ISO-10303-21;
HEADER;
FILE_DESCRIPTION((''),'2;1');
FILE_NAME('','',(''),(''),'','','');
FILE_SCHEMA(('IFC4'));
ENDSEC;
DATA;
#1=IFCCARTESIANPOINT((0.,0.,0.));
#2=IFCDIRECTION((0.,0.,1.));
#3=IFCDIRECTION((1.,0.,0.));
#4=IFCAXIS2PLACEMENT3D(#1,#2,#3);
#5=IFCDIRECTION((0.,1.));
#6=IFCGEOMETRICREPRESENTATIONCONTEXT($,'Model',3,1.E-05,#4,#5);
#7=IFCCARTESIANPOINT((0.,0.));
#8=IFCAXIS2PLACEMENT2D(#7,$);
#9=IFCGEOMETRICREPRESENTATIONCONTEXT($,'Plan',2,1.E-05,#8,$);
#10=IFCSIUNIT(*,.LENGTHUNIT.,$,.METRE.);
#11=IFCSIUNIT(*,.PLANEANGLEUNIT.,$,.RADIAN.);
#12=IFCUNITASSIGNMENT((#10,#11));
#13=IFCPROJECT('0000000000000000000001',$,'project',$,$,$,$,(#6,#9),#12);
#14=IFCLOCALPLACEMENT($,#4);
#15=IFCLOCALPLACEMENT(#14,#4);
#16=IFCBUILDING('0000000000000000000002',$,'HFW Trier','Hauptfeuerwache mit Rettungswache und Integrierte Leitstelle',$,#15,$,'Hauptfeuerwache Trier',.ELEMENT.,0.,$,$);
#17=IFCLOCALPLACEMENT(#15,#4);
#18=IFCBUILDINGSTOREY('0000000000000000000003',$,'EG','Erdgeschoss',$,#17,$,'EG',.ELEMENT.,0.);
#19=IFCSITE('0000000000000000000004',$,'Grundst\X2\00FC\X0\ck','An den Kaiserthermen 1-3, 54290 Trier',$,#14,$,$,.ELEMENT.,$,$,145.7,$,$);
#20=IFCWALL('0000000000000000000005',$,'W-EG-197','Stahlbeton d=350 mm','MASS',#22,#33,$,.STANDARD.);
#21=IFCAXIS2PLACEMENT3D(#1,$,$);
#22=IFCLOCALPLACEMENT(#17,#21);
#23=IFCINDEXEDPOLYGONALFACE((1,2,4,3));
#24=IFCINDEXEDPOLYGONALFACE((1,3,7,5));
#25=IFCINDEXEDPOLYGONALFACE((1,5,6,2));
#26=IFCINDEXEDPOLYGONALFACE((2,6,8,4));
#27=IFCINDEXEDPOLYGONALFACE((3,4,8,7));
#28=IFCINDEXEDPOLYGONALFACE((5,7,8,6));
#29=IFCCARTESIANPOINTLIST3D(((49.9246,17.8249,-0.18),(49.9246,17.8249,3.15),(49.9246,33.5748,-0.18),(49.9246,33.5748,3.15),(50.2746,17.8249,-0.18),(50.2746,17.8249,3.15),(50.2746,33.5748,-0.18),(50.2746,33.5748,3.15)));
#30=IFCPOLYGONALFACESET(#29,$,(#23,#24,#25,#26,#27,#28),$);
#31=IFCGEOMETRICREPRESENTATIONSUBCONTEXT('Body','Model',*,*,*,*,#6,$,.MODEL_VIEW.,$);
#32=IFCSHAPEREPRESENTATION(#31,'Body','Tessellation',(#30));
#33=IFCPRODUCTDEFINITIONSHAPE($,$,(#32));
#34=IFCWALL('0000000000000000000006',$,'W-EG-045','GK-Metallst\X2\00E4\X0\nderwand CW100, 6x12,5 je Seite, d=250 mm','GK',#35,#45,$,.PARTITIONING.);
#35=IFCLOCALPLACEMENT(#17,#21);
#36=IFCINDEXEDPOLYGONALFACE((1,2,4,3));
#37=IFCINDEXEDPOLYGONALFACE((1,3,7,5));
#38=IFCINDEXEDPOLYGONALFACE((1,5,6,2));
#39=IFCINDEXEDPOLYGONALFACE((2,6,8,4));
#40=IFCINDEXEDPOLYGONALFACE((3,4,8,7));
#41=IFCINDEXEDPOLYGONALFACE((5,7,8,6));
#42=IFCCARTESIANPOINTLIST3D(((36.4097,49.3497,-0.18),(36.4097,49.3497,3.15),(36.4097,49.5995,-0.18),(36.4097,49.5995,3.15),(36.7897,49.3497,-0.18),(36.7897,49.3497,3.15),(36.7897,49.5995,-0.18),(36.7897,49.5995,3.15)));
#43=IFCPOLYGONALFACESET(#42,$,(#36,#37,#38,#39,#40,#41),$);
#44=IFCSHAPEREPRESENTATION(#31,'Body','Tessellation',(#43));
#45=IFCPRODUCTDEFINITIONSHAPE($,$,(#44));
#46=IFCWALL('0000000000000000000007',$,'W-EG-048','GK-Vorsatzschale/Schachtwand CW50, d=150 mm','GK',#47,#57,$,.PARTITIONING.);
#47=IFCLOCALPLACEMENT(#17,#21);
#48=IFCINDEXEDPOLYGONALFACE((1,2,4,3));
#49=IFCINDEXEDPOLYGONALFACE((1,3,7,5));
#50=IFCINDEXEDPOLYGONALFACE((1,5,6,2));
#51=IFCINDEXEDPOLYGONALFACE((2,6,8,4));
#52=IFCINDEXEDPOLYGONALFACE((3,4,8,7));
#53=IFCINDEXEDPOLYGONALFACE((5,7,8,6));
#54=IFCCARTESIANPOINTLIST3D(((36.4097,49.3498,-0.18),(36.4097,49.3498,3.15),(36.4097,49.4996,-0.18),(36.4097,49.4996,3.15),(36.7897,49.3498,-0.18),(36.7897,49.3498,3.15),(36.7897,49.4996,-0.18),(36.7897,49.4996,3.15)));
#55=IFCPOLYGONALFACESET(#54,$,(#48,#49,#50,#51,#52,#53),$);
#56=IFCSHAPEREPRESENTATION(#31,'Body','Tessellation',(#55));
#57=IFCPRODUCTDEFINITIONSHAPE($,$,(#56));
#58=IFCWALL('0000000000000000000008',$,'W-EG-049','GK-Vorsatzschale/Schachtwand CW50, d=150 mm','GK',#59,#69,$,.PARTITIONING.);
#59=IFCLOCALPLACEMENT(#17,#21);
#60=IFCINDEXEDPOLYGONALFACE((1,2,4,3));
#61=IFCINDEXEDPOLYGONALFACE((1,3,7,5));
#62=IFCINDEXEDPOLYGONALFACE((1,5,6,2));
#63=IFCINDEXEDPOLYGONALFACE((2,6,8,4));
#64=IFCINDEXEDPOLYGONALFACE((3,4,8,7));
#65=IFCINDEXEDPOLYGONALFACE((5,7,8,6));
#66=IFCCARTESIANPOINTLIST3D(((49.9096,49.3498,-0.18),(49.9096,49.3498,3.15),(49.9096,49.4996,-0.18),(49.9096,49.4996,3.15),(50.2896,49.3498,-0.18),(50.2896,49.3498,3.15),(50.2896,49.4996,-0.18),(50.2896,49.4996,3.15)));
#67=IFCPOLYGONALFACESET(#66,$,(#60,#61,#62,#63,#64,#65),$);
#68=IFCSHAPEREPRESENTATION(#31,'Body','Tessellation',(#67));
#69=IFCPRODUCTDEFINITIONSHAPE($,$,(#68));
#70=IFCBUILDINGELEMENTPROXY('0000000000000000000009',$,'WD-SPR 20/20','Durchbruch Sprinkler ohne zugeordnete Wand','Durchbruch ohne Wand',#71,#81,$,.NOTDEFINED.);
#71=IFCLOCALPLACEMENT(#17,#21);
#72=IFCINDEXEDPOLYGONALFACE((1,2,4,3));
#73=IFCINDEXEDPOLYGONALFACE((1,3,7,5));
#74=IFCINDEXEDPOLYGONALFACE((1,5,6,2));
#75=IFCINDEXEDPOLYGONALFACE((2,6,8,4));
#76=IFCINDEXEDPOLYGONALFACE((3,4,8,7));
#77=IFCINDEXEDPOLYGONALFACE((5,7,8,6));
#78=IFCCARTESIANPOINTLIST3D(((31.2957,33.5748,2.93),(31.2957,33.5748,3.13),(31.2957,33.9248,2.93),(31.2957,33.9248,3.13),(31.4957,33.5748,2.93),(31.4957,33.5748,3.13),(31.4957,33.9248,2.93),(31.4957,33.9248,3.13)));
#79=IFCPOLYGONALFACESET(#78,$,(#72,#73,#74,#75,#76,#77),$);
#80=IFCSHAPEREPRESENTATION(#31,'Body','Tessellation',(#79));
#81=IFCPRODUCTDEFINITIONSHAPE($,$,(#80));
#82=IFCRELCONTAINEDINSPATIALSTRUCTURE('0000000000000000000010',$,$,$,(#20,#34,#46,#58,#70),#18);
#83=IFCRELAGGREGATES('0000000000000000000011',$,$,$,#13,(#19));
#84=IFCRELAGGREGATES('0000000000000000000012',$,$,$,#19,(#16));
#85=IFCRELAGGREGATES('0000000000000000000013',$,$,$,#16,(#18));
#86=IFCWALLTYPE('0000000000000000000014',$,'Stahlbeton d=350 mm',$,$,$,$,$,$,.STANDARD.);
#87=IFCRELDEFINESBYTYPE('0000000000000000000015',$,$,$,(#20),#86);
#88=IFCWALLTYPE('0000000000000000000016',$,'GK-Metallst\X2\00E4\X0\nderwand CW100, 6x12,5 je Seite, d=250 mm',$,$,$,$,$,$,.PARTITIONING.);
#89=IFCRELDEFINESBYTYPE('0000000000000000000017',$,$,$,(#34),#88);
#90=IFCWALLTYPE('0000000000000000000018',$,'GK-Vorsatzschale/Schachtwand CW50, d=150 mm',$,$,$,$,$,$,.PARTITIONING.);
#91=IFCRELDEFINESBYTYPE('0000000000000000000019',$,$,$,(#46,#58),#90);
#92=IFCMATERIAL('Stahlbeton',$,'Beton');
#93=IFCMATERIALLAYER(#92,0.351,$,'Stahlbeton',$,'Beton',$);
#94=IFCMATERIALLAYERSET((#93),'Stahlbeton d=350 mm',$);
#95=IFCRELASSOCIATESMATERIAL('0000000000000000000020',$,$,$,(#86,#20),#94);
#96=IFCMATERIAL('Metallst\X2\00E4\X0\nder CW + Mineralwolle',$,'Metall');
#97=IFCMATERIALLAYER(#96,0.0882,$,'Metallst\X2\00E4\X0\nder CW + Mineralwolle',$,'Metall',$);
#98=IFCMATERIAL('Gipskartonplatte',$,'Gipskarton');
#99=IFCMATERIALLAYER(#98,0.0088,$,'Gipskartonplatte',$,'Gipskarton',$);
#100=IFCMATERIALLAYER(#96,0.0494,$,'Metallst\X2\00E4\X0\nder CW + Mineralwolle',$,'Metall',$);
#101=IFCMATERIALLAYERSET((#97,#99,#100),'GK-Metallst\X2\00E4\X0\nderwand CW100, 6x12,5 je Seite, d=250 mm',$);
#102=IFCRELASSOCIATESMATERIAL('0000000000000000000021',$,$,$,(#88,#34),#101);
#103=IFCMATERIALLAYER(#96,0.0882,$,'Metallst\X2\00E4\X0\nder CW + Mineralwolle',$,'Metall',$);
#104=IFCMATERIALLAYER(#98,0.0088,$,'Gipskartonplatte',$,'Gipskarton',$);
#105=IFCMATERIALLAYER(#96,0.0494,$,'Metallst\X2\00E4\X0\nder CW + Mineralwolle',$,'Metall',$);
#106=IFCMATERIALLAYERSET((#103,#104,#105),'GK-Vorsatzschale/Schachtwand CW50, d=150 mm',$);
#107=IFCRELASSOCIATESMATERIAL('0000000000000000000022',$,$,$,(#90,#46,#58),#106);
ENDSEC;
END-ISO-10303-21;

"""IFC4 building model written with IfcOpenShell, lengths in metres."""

from ifc_helpers import new_model, si_unit, direction, frame, frame_2d, origin_with_axes, origin_2d, place, context, subcontext, project, spatial, rectangle, extrude, material, layer, layer_set, layer_usage, type_object, element, save


model = new_model("IFC4")

# Units and contexts
model_context = context("Model", 3, precision=1e-05, world=origin_with_axes(), true_north=direction((0.0, 1.0)))
plan_context = context("Plan", 2, precision=1e-05, world=origin_2d())
body_context = subcontext(model_context, "Body", "Model", "MODEL_VIEW")
ifc_project = project(units=[si_unit("LENGTHUNIT", "METRE"), si_unit("PLANEANGLEUNIT", "RADIAN")], contexts=[model_context, plan_context])

# Site, building, storey
site_placement = place(None, origin_with_axes())
site = spatial("IfcSite", under=ifc_project, at=site_placement, Name="Grundstück", Description="An den Kaiserthermen 1-3, 54290 Trier", CompositionType="ELEMENT", RefElevation=145.7)
building_placement = place(site_placement, origin_with_axes())
building = spatial("IfcBuilding", under=site, at=building_placement, Name="HFW Trier", Description="Hauptfeuerwache mit Rettungswache und Integrierte Leitstelle", LongName="Hauptfeuerwache Trier", CompositionType="ELEMENT", ElevationOfRefHeight=0.0)
storey_placement = place(building_placement, origin_with_axes())
storey = spatial("IfcBuildingStorey", under=building, at=storey_placement, Name="EG", Description="Erdgeschoss", LongName="EG", CompositionType="ELEMENT", Elevation=0.0)

# Shared definitions
ifc_material_1 = material(Name="Stahlbeton", Category="Beton")

# Shared definitions
ifc_material_2 = material(Name="Gipskartonplatte", Category="Gipskarton")
ifc_material_3 = material(Name="Metallständer CW + Mineralwolle", Category="Metall")

# Shared definitions
ifc_layer_1 = layer(ifc_material_1, 0.351, Name="Stahlbeton", Category="Beton")
ifc_layer_set_1 = layer_set([ifc_layer_1], Name="Stahlbeton d=350 mm")
wall_type_1 = type_object("IfcWallType", Name="Stahlbeton d=350 mm", PredefinedType="STANDARD", material=ifc_layer_set_1)

# Walls
ifc_layer_usage_1 = layer_usage(ifc_layer_set_1, "AXIS2", "POSITIVE", -0.175)
wall_1_placement = place(storey_placement, frame((50.0996, 33.5748, -0.18), z_axis=(0.0, 0.0, 1.0), x_axis=(0.0, -1.0, 0.0)))
element("IfcWall", 1, at=wall_1_placement, inside=storey, type_object=wall_type_1, material=ifc_layer_usage_1, Name="W-EG-197", Description="Stahlbeton d=350 mm", ObjectType="MASS", PredefinedType="STANDARD", context=body_context, shape_type="SweptSolid", body=[
    extrude(rectangle(XDim=15.7499, YDim=0.35, at=frame_2d((7.875, 0.0))), origin_with_axes(), (0.0, 0.0, 1.0), 3.33),
])
ifc_layer_2 = layer(ifc_material_3, 0.0882, Name="Metallständer CW + Mineralwolle", Category="Metall")
ifc_layer_3 = layer(ifc_material_2, 0.0088, Name="Gipskartonplatte", Category="Gipskarton")
ifc_layer_4 = layer(ifc_material_3, 0.0494, Name="Metallständer CW + Mineralwolle", Category="Metall")
ifc_layer_set_2 = layer_set([ifc_layer_2, ifc_layer_3, ifc_layer_4], Name="GK-Metallständerwand CW100, 6x12,5 je Seite, d=250 mm")
ifc_layer_usage_2 = layer_usage(ifc_layer_set_2, "AXIS2", "POSITIVE", -0.1249)
wall_type_2 = type_object("IfcWallType", Name="GK-Metallständerwand CW100, 6x12,5 je Seite, d=250 mm", PredefinedType="PARTITIONING", material=ifc_layer_set_2)
wall_2_placement = place(storey_placement, frame((36.4097, 49.4746, -0.18), z_axis=(0.0, 0.0, 1.0), x_axis=(1.0, 0.0, 0.0)))
element("IfcWall", 2, at=wall_2_placement, inside=storey, type_object=wall_type_2, material=ifc_layer_usage_2, Name="W-EG-045", Description="GK-Metallständerwand CW100, 6x12,5 je Seite, d=250 mm", ObjectType="GK", PredefinedType="PARTITIONING", context=body_context, shape_type="SweptSolid", body=[
    extrude(rectangle(XDim=0.38, YDim=0.2498, at=frame_2d((0.19, 0.0))), origin_with_axes(), (0.0, 0.0, 1.0), 3.33),
])
ifc_layer_5 = layer(ifc_material_3, 0.0882, Name="Metallständer CW + Mineralwolle", Category="Metall")
ifc_layer_6 = layer(ifc_material_2, 0.0088, Name="Gipskartonplatte", Category="Gipskarton")
ifc_layer_7 = layer(ifc_material_3, 0.0494, Name="Metallständer CW + Mineralwolle", Category="Metall")
ifc_layer_set_3 = layer_set([ifc_layer_5, ifc_layer_6, ifc_layer_7], Name="GK-Vorsatzschale/Schachtwand CW50, d=150 mm")
ifc_layer_usage_3 = layer_usage(ifc_layer_set_3, "AXIS2", "POSITIVE", -0.075)
wall_type_3 = type_object("IfcWallType", Name="GK-Vorsatzschale/Schachtwand CW50, d=150 mm", PredefinedType="PARTITIONING", material=ifc_layer_set_3)
wall_3_placement = place(storey_placement, frame((36.4097, 49.4247, -0.18), z_axis=(0.0, 0.0, 1.0), x_axis=(1.0, 0.0, 0.0)))
element("IfcWall", 3, at=wall_3_placement, inside=storey, type_object=wall_type_3, material=ifc_layer_usage_3, Name="W-EG-048", Description="GK-Vorsatzschale/Schachtwand CW50, d=150 mm", ObjectType="GK", PredefinedType="PARTITIONING", context=body_context, shape_type="SweptSolid", body=[
    extrude(rectangle(XDim=0.38, YDim=0.1499, at=frame_2d((0.19, 0.0))), origin_with_axes(), (0.0, 0.0, 1.0), 3.33),
])
ifc_layer_usage_4 = layer_usage(ifc_layer_set_3, "AXIS2", "POSITIVE", -0.075)
wall_4_placement = place(storey_placement, frame((49.9096, 49.4247, -0.18), z_axis=(0.0, 0.0, 1.0), x_axis=(1.0, 0.0, 0.0)))
element("IfcWall", 4, at=wall_4_placement, inside=storey, type_object=wall_type_3, material=ifc_layer_usage_4, Name="W-EG-049", Description="GK-Vorsatzschale/Schachtwand CW50, d=150 mm", ObjectType="GK", PredefinedType="PARTITIONING", context=body_context, shape_type="SweptSolid", body=[
    extrude(rectangle(XDim=0.38, YDim=0.1499, at=frame_2d((0.19, 0.0))), origin_with_axes(), (0.0, 0.0, 1.0), 3.33),
])

# Building element proxy
proxy_placement = place(storey_placement, frame((31.3957, 33.7498, 2.93), z_axis=(0.0, 0.0, 1.0), x_axis=(1.0, 0.0, 0.0)))
element("IfcBuildingElementProxy", 5, at=proxy_placement, inside=storey, Name="WD-SPR 20/20", Description="Durchbruch Sprinkler ohne zugeordnete Wand", ObjectType="Durchbruch ohne Wand", PredefinedType="NOTDEFINED", context=body_context, shape_type="SweptSolid", body=[
    extrude(rectangle(XDim=0.2, YDim=0.35, at=origin_2d()), origin_with_axes(), (0.0, 0.0, 1.0), 0.2),
])

save(model, "model.ifc")
